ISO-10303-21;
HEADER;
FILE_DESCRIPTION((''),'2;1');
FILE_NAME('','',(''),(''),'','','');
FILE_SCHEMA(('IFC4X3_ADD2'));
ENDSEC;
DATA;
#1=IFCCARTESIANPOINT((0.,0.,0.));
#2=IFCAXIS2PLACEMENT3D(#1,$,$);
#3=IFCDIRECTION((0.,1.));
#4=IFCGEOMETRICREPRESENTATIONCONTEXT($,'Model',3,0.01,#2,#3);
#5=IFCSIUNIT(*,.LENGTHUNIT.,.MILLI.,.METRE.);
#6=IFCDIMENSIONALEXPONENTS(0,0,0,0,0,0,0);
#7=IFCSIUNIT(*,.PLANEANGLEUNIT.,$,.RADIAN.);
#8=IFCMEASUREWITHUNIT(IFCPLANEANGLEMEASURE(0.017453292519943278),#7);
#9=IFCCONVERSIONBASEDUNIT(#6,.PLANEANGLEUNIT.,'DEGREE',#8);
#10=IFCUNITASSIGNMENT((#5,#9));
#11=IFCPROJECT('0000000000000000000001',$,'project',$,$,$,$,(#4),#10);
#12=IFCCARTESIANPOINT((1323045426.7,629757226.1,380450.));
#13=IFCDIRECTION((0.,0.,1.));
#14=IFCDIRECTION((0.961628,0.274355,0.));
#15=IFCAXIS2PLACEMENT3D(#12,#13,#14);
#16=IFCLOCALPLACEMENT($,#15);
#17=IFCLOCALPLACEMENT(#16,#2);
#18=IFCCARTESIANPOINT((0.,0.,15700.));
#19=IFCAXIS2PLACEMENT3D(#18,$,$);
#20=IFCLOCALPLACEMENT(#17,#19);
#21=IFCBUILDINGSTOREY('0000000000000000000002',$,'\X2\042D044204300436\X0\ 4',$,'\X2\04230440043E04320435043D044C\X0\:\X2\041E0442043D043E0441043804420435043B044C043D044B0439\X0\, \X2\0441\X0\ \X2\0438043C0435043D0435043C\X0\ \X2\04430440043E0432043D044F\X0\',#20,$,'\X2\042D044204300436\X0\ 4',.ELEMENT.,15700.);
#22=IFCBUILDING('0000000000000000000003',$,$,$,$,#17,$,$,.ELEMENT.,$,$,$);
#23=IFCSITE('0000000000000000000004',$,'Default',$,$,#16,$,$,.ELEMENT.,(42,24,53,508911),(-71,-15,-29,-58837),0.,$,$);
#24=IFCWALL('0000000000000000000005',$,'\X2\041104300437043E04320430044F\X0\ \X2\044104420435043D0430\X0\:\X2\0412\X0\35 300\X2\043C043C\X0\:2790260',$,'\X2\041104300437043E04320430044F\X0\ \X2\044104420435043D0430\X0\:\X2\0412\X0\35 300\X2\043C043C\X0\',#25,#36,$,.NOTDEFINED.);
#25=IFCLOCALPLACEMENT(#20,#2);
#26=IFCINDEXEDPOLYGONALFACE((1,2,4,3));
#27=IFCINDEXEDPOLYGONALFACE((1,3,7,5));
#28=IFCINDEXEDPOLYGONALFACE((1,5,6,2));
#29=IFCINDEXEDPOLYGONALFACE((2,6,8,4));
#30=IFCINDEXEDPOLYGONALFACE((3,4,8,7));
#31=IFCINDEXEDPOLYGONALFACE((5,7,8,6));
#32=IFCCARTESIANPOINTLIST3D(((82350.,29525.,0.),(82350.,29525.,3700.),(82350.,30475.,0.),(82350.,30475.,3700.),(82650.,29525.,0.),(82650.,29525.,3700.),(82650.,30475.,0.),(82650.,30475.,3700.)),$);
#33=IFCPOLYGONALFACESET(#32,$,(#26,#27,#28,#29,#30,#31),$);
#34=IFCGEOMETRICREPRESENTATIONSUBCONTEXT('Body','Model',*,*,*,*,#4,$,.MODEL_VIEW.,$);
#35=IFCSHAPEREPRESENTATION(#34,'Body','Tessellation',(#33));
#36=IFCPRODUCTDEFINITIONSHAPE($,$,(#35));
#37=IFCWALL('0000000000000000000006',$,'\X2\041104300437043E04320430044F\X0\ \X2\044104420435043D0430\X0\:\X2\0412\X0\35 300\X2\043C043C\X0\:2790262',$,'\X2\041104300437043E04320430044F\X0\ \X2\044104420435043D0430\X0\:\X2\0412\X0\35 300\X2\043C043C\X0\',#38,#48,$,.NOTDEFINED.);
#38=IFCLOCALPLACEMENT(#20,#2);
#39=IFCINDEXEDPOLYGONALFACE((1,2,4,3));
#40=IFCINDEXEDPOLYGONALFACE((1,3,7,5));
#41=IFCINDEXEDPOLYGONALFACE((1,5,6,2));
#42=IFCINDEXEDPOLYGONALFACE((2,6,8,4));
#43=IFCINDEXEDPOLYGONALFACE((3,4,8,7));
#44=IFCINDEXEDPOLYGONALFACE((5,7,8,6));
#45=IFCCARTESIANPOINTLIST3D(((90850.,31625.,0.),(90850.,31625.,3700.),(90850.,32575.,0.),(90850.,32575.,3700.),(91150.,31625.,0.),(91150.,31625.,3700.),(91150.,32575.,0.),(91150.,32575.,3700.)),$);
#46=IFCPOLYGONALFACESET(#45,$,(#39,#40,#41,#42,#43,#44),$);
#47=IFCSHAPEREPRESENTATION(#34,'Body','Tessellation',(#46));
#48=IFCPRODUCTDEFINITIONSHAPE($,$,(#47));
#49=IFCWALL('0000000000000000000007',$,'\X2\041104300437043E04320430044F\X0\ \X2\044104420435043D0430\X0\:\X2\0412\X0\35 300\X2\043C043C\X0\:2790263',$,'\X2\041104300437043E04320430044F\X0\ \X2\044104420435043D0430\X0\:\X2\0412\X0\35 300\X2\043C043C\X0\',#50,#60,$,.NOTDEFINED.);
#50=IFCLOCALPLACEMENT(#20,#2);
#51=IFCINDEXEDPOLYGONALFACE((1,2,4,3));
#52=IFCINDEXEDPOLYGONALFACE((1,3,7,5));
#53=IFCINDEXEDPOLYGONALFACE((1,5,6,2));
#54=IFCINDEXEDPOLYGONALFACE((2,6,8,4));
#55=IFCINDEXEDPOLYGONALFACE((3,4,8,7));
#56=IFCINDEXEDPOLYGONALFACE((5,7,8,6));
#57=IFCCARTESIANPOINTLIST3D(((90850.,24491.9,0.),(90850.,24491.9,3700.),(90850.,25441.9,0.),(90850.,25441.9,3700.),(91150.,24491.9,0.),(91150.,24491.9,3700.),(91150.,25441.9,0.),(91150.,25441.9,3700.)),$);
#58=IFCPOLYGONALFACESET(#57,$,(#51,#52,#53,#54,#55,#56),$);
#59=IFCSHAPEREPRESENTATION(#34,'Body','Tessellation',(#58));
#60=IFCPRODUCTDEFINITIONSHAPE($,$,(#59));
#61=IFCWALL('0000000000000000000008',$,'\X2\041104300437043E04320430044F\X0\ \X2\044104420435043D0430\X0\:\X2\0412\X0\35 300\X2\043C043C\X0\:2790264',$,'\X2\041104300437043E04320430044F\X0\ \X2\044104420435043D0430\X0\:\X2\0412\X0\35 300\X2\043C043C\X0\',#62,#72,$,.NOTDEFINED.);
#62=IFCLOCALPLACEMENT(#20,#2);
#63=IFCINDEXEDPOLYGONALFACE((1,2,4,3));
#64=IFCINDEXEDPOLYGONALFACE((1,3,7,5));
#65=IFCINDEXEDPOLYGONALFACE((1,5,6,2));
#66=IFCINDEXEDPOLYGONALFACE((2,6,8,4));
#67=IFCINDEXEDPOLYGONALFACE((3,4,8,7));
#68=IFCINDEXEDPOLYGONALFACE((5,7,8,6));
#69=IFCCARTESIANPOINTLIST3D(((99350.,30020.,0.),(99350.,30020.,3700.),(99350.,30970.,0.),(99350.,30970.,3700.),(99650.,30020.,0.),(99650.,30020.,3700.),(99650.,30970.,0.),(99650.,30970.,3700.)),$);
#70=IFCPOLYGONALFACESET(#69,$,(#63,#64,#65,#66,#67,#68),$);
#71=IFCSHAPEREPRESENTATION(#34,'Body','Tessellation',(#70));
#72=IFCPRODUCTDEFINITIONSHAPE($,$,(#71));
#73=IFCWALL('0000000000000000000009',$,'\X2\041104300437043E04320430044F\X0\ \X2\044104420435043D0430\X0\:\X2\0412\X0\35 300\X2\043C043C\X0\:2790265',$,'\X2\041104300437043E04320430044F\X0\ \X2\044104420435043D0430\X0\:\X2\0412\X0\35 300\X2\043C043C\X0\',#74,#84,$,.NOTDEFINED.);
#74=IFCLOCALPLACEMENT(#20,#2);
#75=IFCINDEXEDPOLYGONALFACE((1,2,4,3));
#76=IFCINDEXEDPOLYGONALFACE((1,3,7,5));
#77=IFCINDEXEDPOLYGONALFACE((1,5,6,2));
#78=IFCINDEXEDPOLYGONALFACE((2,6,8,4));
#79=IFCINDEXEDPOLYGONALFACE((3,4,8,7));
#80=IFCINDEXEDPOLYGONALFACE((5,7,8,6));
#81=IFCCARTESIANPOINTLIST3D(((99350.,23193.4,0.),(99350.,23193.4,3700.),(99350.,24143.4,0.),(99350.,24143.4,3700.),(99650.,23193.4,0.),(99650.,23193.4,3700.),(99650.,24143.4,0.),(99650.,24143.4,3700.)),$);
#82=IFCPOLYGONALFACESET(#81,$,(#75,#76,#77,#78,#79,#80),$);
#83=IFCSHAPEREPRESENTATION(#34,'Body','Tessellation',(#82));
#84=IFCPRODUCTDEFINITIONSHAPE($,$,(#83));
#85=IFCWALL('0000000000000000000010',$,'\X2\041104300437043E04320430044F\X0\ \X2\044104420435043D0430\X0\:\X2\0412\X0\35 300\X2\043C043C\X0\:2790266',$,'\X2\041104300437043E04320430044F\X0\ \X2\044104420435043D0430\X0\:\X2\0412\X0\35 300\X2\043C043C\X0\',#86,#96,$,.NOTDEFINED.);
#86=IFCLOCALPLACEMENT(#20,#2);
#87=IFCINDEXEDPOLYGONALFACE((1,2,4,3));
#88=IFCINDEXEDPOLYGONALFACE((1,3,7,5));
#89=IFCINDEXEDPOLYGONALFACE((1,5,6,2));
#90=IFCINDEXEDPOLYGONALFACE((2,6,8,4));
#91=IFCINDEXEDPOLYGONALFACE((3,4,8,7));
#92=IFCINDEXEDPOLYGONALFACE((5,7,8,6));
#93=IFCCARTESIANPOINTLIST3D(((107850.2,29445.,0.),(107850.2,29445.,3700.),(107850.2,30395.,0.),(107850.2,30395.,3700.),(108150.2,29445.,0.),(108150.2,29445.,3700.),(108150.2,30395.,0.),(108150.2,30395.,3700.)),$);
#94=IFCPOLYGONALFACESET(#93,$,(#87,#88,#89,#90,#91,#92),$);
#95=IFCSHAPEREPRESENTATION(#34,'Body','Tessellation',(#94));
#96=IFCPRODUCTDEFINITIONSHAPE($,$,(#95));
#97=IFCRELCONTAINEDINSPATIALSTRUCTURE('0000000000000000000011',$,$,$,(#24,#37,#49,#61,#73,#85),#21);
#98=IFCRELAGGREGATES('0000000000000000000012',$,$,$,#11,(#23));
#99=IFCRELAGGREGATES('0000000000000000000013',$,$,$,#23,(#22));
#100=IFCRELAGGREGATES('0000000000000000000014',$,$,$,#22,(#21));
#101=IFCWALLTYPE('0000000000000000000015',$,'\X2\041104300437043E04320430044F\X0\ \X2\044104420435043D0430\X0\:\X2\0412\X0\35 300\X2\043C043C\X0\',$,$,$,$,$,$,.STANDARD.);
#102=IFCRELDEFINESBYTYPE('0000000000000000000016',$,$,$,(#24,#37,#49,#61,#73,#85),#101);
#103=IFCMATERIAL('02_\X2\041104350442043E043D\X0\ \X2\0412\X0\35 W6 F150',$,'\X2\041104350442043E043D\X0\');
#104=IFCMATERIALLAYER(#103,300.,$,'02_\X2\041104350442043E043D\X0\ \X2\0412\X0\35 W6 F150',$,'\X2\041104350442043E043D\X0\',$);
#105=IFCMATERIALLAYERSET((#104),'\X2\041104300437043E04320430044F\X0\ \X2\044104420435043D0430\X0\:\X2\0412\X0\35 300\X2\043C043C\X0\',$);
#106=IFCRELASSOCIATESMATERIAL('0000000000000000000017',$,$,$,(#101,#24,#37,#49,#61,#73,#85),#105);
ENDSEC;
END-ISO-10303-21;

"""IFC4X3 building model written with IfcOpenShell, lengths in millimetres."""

from ifc_helpers import new_model, entity, si_unit, converted_unit, direction, frame, frame_2d, origin, place, context, subcontext, project, spatial, rectangle, extrude, material, layer, layer_set, type_object, element, save


model = new_model("IFC4X3")

# Units and contexts
model_context = context("Model", 3, precision=0.01, world=origin(), true_north=direction((0.0, 1.0)))
body_context = subcontext(model_context, "Body", "Model", "MODEL_VIEW")
ifc_project = project(units=[si_unit("LENGTHUNIT", "METRE", prefix="MILLI"), converted_unit("PLANEANGLEUNIT", "DEGREE", entity("IfcPlaneAngleMeasure", 0.017453292519943278), si_unit("PLANEANGLEUNIT", "RADIAN"), dimensions=[0, 0, 0, 0, 0, 0, 0])], contexts=[model_context])

# Site, building, storey
site_placement = place(None, frame((1323045426.7, 629757226.1, 380450.0), z_axis=(0.0, 0.0, 1.0), x_axis=(0.961628, 0.274355, 0.0)))
site = spatial("IfcSite", under=ifc_project, at=site_placement, Name="Default", CompositionType="ELEMENT", RefLatitude=(42, 24, 53, 508911), RefLongitude=(-71, -15, -29, -58837), RefElevation=0.0)
building_placement = place(site_placement, origin())
building = spatial("IfcBuilding", under=site, at=building_placement, CompositionType="ELEMENT")
storey_placement = place(building_placement, frame((0.0, 0.0, 15700.0)))
storey = spatial("IfcBuildingStorey", under=building, at=storey_placement, Name="Этаж 4", ObjectType="Уровень:Относительный, с именем уровня", LongName="Этаж 4", CompositionType="ELEMENT", Elevation=15700.0)

# Shared definitions
ifc_material = material(Name="02_Бетон В35 W6 F150", Category="Бетон")

# Walls
ifc_layer_1 = layer(ifc_material, 300.0, Name="02_Бетон В35 W6 F150", Category="Бетон")
ifc_layer_set_1 = layer_set([ifc_layer_1], Name="Базовая стена:В35 300мм")
wall_type_1 = type_object("IfcWallType", Name="Базовая стена:В35 300мм", PredefinedType="STANDARD", material=ifc_layer_set_1)
for number, where, z_axis, x_axis, name in (
    (1, (82500.0, 29525.0, 0.0), (0.0, 0.0, 1.0), (0.0, 1.0, 0.0), "Базовая стена:В35 300мм:2790260"),
    (2, (91000.0, 31625.0, 0.0), (0.0, 0.0, 1.0), (0.0, 1.0, 0.0), "Базовая стена:В35 300мм:2790262"),
    (3, (91000.0, 24491.9, 0.0), (0.0, 0.0, 1.0), (0.0, 1.0, 0.0), "Базовая стена:В35 300мм:2790263"),
    (4, (99500.0, 30020.0, 0.0), (0.0, 0.0, 1.0), (0.0, 1.0, 0.0), "Базовая стена:В35 300мм:2790264"),
    (5, (99500.0, 23193.4, 0.0), (0.0, 0.0, 1.0), (0.0, 1.0, 0.0), "Базовая стена:В35 300мм:2790265"),
    (6, (108000.2, 29445.0, 0.0), (0.0, 0.0, 1.0), (0.0, 1.0, 0.0), "Базовая стена:В35 300мм:2790266"),
):
    element("IfcWall", number, at=place(storey_placement, frame(where, z_axis=z_axis, x_axis=x_axis)), inside=storey, type_object=wall_type_1, material=ifc_layer_set_1, Name=name, ObjectType="Базовая стена:В35 300мм", PredefinedType="NOTDEFINED", context=body_context, shape_type="SweptSolid", body=[
        extrude(rectangle(XDim=950.0, YDim=300.0, at=frame_2d((475.0, 0.0), x_axis=(-1.0, 0.0))), origin(), (0.0, 0.0, 1.0), 3700.0),
    ])

save(model, "model.ifc")
